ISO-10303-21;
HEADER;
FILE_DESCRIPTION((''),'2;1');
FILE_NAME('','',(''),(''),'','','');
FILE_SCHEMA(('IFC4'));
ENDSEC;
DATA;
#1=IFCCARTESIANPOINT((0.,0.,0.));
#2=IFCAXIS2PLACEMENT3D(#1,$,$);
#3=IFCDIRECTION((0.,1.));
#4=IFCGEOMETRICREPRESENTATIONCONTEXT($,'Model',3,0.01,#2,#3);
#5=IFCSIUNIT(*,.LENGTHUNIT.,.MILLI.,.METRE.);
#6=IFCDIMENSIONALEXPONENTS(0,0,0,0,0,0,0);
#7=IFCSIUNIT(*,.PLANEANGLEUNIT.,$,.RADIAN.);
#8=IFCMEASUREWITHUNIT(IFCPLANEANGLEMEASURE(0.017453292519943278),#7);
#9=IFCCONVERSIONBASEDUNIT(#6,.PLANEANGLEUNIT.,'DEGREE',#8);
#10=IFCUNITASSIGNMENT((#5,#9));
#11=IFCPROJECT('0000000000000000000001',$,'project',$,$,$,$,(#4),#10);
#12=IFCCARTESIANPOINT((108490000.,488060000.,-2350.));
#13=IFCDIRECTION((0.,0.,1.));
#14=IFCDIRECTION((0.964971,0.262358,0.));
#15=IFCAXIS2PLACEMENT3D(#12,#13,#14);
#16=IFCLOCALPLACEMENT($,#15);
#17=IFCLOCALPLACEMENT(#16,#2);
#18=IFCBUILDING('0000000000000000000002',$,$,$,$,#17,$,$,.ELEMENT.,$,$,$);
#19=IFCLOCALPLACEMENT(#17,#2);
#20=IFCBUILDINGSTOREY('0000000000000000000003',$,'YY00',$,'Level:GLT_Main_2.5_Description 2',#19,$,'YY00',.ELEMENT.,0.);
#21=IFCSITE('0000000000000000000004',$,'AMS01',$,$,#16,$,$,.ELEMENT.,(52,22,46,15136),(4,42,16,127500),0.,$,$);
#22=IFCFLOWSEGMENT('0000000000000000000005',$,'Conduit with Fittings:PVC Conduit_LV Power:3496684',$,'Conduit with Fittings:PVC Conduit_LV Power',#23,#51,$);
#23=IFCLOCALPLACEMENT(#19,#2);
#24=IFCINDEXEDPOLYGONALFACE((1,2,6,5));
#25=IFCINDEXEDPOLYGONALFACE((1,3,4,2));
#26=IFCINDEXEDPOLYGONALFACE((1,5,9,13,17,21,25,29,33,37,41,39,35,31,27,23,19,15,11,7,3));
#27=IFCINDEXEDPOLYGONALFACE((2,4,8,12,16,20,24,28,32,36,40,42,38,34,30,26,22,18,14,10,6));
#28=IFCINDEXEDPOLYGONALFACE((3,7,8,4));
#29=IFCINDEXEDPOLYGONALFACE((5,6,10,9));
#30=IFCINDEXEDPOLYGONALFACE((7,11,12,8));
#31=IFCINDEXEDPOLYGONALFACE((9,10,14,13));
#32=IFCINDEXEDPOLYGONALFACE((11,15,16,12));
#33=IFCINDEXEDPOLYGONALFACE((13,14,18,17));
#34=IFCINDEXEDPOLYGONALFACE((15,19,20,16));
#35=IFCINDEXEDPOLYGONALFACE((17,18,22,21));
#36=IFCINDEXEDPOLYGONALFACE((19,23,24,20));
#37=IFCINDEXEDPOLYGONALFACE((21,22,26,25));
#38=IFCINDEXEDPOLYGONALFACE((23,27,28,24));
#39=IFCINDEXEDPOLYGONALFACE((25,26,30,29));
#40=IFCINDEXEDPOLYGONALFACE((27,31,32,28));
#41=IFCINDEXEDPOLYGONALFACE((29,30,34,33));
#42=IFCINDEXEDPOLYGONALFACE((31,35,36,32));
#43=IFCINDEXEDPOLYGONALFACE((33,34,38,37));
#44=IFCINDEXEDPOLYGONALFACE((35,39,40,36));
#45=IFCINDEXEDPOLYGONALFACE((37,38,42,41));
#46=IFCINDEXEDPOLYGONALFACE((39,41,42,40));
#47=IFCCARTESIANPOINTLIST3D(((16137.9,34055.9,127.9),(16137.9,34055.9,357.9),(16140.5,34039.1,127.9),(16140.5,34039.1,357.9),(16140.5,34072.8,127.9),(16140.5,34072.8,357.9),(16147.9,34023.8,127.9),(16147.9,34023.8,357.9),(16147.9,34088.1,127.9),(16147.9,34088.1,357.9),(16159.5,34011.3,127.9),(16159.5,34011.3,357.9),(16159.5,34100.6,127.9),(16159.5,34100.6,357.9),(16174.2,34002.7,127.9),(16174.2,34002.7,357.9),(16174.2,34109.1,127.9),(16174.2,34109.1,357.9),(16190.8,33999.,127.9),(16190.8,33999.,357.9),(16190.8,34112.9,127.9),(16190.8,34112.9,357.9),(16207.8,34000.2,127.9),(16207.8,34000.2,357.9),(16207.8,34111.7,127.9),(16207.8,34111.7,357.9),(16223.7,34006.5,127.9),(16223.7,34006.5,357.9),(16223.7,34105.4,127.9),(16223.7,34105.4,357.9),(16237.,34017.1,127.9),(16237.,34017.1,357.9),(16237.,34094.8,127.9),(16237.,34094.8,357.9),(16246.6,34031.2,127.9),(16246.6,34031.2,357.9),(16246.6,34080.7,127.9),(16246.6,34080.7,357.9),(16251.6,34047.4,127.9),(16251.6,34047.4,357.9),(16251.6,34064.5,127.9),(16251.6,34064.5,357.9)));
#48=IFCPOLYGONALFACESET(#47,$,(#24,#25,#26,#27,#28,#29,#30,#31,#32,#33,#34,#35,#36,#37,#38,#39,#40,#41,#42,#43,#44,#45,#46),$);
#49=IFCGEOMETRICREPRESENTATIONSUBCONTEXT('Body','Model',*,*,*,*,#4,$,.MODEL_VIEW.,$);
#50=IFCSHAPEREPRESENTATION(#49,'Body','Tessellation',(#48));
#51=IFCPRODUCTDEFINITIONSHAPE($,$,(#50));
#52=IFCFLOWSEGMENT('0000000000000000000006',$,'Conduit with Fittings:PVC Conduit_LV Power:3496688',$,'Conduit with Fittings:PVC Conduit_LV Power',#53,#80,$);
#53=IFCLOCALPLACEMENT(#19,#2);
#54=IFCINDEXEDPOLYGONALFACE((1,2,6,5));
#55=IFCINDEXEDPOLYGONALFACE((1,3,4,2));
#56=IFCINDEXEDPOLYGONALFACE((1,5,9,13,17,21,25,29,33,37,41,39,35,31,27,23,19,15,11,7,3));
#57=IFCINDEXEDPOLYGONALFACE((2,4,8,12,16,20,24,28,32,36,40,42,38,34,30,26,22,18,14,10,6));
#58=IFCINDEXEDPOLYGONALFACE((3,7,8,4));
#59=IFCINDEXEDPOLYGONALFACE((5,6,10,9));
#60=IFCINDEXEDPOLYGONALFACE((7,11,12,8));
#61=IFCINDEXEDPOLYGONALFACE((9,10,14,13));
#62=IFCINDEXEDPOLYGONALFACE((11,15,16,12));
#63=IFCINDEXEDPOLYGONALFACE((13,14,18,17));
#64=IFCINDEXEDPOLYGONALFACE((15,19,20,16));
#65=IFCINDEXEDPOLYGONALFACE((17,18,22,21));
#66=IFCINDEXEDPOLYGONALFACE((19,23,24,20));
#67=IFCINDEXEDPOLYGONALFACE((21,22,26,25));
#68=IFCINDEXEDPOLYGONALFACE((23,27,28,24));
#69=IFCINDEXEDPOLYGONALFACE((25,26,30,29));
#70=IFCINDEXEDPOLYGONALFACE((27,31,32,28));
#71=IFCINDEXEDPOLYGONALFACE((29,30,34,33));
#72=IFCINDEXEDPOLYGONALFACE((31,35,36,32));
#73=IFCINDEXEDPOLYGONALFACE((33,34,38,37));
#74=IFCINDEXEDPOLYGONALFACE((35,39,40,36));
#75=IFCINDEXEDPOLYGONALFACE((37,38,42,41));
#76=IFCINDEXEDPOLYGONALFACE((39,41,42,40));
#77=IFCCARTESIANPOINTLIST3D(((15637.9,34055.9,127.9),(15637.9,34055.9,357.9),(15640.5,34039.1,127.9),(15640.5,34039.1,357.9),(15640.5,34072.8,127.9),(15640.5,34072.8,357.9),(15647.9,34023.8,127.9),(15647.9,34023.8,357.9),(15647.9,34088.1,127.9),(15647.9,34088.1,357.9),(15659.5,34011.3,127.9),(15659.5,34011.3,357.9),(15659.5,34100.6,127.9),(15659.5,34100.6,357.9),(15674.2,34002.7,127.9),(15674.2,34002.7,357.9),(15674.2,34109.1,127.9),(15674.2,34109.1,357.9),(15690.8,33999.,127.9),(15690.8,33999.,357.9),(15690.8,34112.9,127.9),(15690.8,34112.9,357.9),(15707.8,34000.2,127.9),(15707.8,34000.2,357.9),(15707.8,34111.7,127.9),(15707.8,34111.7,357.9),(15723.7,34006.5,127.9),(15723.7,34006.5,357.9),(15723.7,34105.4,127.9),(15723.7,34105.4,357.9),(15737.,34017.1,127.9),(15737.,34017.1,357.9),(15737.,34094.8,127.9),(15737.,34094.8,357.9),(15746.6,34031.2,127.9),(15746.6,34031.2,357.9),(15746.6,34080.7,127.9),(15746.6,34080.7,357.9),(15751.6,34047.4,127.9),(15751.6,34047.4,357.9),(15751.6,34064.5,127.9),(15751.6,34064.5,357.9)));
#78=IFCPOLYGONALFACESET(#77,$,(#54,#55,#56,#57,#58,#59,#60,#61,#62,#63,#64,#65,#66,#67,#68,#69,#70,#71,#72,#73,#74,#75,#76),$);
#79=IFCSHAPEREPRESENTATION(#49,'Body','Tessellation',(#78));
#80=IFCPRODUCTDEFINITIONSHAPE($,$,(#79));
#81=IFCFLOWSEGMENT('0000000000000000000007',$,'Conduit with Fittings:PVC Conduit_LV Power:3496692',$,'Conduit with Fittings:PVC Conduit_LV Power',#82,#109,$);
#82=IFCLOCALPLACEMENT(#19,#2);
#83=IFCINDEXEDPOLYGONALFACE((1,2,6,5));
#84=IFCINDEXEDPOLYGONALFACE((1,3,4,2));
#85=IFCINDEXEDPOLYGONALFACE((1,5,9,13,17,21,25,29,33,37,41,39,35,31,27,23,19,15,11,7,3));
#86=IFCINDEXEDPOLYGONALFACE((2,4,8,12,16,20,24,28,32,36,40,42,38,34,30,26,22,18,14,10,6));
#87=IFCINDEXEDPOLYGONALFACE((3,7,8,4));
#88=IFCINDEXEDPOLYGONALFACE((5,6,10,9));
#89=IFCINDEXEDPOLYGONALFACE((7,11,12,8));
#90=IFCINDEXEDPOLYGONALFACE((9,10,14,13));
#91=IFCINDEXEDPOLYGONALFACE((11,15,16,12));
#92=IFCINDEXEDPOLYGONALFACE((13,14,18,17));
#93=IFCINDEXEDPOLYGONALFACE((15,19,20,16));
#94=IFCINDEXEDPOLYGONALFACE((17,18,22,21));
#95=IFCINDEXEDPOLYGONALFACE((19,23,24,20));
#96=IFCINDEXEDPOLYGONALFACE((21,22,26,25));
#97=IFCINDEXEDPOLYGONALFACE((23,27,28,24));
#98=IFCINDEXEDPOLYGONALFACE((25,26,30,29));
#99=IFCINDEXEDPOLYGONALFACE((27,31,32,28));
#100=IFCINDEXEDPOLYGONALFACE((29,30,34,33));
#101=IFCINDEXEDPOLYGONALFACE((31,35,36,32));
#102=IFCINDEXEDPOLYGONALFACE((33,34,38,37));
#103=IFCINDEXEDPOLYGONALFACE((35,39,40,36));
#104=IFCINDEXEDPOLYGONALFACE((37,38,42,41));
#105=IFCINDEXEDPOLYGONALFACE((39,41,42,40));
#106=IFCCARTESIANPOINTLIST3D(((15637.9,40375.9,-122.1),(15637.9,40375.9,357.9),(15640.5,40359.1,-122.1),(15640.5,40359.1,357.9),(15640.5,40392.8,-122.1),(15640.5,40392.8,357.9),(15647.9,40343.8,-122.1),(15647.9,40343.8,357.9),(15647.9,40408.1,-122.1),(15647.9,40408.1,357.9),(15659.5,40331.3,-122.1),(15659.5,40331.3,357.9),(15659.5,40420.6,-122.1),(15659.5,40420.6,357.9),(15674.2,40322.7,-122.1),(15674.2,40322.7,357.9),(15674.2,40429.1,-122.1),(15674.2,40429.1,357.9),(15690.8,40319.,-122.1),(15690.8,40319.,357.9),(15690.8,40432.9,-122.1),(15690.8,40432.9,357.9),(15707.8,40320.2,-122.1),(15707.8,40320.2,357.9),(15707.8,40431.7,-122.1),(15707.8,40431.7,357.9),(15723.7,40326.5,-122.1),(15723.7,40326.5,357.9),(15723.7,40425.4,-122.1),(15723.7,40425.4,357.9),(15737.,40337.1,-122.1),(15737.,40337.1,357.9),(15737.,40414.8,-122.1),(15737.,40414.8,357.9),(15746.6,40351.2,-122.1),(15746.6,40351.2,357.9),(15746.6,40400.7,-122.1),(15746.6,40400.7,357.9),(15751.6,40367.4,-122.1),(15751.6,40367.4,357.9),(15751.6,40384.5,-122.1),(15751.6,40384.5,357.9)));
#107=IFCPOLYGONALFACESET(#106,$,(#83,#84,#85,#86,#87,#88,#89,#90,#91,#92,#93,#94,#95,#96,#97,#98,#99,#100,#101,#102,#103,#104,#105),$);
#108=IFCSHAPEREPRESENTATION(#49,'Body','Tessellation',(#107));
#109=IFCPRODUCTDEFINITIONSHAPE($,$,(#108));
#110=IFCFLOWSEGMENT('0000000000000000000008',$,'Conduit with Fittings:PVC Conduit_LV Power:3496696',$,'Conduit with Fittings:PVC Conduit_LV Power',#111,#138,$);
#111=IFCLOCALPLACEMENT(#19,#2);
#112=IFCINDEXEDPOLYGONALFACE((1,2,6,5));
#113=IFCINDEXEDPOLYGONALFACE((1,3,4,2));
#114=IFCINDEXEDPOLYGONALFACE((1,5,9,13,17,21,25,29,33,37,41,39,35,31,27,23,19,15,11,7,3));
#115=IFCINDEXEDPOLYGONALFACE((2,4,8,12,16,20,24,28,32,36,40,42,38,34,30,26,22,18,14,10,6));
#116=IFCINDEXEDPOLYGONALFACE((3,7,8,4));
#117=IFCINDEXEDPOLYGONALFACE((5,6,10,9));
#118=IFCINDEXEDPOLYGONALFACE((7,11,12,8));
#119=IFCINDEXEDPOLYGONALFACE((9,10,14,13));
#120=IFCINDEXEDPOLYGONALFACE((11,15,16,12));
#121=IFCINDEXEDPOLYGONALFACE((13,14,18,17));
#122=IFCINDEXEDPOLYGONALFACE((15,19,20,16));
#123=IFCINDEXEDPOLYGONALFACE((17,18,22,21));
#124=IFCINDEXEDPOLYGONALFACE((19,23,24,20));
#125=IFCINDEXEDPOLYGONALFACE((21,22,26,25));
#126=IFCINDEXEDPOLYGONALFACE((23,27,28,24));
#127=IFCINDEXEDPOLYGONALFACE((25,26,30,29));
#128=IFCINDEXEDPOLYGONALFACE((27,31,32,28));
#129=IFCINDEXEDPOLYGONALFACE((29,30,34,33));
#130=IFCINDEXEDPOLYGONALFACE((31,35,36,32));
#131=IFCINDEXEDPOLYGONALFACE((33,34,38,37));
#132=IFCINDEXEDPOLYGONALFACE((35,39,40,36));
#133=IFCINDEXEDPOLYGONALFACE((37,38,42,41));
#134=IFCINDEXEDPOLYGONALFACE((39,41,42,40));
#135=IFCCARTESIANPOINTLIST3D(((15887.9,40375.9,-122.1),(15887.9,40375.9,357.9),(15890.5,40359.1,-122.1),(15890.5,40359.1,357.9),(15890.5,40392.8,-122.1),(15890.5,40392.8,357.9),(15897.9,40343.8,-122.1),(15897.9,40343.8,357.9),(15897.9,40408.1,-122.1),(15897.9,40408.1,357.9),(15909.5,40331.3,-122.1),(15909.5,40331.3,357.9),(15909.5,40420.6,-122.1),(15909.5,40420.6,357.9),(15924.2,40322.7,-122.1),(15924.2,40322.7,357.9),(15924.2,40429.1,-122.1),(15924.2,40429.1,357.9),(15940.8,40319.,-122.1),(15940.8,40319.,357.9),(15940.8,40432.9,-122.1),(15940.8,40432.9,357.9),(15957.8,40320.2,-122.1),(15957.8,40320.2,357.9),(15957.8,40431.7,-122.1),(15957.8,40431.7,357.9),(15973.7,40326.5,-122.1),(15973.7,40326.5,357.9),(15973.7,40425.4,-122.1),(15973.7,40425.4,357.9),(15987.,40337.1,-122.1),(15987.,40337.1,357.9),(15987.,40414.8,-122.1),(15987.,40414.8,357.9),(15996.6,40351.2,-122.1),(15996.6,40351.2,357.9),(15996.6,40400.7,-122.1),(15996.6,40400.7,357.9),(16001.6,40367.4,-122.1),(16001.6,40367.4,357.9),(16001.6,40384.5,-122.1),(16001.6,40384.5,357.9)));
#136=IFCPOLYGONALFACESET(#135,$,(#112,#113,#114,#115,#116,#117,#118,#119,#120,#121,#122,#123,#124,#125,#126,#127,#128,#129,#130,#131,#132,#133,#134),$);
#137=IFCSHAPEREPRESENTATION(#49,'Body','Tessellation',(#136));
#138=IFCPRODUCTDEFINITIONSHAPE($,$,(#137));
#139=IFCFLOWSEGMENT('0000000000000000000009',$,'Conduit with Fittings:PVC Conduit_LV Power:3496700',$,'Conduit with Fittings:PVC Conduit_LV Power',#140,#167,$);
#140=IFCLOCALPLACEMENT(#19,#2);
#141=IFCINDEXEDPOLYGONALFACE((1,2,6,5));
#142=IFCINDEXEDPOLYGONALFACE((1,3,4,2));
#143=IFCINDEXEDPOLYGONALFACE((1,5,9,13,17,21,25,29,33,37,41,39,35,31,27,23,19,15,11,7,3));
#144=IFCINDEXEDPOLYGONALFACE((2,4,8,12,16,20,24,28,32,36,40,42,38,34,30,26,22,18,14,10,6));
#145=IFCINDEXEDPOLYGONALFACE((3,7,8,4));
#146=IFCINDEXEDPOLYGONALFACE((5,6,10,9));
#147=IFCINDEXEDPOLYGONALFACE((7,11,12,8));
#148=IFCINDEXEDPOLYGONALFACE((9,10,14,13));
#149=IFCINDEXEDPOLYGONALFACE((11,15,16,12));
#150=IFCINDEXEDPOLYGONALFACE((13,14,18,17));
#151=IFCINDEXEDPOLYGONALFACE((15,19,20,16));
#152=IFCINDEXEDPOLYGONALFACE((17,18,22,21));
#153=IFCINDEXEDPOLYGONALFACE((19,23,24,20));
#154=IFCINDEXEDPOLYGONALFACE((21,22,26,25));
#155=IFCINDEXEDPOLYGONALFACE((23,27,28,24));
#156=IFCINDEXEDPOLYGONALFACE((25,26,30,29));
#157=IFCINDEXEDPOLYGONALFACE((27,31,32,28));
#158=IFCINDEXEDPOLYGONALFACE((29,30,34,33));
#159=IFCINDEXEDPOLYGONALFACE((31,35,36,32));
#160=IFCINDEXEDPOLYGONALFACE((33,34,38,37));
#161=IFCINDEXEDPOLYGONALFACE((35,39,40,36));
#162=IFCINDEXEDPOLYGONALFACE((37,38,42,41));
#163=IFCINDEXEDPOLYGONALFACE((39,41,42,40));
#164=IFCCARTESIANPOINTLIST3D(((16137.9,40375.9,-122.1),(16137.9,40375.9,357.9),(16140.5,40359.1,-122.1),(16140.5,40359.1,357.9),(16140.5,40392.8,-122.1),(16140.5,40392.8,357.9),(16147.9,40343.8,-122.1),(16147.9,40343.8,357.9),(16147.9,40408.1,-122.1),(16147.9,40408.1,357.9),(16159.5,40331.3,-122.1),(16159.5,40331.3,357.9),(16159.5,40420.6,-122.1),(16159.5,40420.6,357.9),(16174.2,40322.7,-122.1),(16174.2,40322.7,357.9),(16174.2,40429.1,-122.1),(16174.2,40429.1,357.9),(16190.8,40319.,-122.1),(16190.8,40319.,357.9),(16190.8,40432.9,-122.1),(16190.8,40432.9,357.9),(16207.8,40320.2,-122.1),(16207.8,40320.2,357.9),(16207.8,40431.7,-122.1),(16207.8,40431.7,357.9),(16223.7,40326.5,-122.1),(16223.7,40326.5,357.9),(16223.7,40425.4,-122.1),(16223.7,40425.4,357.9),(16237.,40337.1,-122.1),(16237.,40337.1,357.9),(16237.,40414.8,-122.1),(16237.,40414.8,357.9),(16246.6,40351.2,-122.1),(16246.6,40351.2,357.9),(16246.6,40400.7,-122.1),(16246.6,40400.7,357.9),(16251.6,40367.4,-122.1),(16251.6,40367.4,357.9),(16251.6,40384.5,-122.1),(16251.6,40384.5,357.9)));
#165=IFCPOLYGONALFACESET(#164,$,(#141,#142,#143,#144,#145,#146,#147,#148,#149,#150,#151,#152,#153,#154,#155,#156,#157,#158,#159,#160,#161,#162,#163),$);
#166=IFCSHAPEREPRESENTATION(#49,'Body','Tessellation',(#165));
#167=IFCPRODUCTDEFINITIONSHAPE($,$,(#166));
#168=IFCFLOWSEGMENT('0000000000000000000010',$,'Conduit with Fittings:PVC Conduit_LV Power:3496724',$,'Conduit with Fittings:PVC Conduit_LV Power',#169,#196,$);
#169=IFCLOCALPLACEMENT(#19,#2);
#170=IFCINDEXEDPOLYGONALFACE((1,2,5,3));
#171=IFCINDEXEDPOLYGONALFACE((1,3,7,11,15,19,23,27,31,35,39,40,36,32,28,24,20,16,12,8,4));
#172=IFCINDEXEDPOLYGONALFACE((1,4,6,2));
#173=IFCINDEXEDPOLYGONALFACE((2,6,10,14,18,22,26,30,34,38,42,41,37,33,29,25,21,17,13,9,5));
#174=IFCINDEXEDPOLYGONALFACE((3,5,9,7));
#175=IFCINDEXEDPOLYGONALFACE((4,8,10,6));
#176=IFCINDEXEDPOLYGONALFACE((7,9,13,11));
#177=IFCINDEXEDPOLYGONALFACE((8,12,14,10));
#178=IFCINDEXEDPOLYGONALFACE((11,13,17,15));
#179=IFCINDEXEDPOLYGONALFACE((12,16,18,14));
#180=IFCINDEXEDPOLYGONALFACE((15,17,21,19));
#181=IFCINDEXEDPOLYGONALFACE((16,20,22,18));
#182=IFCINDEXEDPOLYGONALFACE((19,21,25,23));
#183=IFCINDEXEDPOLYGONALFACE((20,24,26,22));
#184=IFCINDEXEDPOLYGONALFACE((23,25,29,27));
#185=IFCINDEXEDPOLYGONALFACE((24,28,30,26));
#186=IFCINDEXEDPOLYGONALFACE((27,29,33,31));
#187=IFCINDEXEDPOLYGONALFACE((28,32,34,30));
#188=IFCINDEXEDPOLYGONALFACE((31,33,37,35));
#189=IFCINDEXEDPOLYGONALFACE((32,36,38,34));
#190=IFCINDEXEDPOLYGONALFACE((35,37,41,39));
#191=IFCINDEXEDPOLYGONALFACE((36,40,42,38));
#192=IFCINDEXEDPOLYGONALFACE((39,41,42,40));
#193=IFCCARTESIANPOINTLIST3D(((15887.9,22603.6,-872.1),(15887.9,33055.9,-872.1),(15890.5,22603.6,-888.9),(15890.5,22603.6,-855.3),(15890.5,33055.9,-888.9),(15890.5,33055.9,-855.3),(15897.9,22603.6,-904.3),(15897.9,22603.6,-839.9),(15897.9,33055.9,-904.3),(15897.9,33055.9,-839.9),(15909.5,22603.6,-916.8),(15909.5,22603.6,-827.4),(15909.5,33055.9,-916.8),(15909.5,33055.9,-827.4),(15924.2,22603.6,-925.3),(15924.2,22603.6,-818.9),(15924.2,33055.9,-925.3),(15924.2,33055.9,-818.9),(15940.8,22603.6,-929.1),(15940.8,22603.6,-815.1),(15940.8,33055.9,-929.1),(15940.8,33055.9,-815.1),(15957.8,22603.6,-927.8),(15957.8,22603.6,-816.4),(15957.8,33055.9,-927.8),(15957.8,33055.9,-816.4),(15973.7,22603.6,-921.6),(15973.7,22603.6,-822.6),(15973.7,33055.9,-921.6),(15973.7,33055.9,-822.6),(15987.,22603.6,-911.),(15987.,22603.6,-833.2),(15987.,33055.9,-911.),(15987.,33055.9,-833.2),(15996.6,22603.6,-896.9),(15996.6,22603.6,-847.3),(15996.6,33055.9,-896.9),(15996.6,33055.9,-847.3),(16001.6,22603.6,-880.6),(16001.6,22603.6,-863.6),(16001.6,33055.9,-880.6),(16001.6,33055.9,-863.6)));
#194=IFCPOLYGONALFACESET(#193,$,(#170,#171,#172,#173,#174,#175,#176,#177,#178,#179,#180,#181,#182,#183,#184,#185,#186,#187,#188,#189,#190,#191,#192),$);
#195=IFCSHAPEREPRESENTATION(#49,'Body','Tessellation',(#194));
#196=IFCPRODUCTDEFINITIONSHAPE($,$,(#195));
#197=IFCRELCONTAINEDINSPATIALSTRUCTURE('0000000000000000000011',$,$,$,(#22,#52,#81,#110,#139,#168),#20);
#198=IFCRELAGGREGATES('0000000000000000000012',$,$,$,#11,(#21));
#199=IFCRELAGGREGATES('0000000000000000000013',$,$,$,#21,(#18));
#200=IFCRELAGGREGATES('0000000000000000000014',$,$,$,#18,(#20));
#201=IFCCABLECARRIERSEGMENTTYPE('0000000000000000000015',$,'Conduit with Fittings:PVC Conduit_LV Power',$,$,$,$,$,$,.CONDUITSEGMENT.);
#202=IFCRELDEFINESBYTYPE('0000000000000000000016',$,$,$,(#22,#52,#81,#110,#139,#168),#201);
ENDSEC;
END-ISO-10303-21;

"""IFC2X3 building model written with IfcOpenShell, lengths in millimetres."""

from ifc_helpers import new_model, entity, si_unit, converted_unit, direction, frame, frame_2d, origin, origin_2d_with_axis, place, context, subcontext, project, spatial, circle, extrude, type_object, element, save


model = new_model("IFC2X3")

# Units and contexts
model_context = context("Model", 3, precision=0.01, world=origin(), true_north=direction((0.0, 1.0)))
body_context = subcontext(model_context, "Body", "Model", "MODEL_VIEW")
ifc_project = project(units=[si_unit("LENGTHUNIT", "METRE", prefix="MILLI"), converted_unit("PLANEANGLEUNIT", "DEGREE", entity("IfcPlaneAngleMeasure", 0.017453292519943278), si_unit("PLANEANGLEUNIT", "RADIAN"), dimensions=[0, 0, 0, 0, 0, 0, 0])], contexts=[model_context])

# Site, building, storey
site_placement = place(None, frame((108490000.0, 488060000.0, -2350.0), z_axis=(0.0, 0.0, 1.0), x_axis=(0.964971, 0.262358, 0.0)))
site = spatial("IfcSite", under=ifc_project, at=site_placement, Name="AMS01", CompositionType="ELEMENT", RefLatitude=(52, 22, 46, 15136), RefLongitude=(4, 42, 16, 127500), RefElevation=0.0)
building_placement = place(site_placement, origin())
building = spatial("IfcBuilding", under=site, at=building_placement, CompositionType="ELEMENT")
storey_placement = place(building_placement, origin())
storey = spatial("IfcBuildingStorey", under=building, at=storey_placement, Name="YY00", ObjectType="Level:GLT_Main_2.5_Description 2", LongName="YY00", CompositionType="ELEMENT", Elevation=0.0)

# Flow segments
cable_carrier_segment_type = type_object("IfcCableCarrierSegmentType", Name="Conduit with Fittings:PVC Conduit_LV Power", PredefinedType="CONDUITSEGMENT")
flow_segment_1_placement = place(storey_placement, origin())
element("IfcFlowSegment", 1, at=flow_segment_1_placement, inside=storey, type_object=cable_carrier_segment_type, Name="Conduit with Fittings:PVC Conduit_LV Power:3496684", ObjectType="Conduit with Fittings:PVC Conduit_LV Power", context=body_context, shape_type="SweptSolid", body=[
    extrude(circle(Radius=57.2, at=origin_2d_with_axis()), frame((16195.1, 34055.9, 127.9), z_axis=(0.0, 0.0, 1.0), x_axis=(-1.0, 0.0, 0.0)), (0.0, 0.0, 1.0), 230.0),
])
flow_segment_2_placement = place(storey_placement, origin())
element("IfcFlowSegment", 2, at=flow_segment_2_placement, inside=storey, type_object=cable_carrier_segment_type, Name="Conduit with Fittings:PVC Conduit_LV Power:3496688", ObjectType="Conduit with Fittings:PVC Conduit_LV Power", context=body_context, shape_type="SweptSolid", body=[
    extrude(circle(Radius=57.2, at=origin_2d_with_axis()), frame((15695.1, 34055.9, 127.9), z_axis=(0.0, 0.0, 1.0), x_axis=(-1.0, 0.0, 0.0)), (0.0, 0.0, 1.0), 230.0),
])
flow_segment_3_placement = place(storey_placement, origin())
element("IfcFlowSegment", 3, at=flow_segment_3_placement, inside=storey, type_object=cable_carrier_segment_type, Name="Conduit with Fittings:PVC Conduit_LV Power:3496692", ObjectType="Conduit with Fittings:PVC Conduit_LV Power", context=body_context, shape_type="SweptSolid", body=[
    extrude(circle(Radius=57.2, at=origin_2d_with_axis()), frame((15695.1, 40375.9, -122.1), z_axis=(0.0, 0.0, 1.0), x_axis=(-1.0, 0.0, 0.0)), (0.0, 0.0, 1.0), 480.0),
])
flow_segment_4_placement = place(storey_placement, origin())
element("IfcFlowSegment", 4, at=flow_segment_4_placement, inside=storey, type_object=cable_carrier_segment_type, Name="Conduit with Fittings:PVC Conduit_LV Power:3496696", ObjectType="Conduit with Fittings:PVC Conduit_LV Power", context=body_context, shape_type="SweptSolid", body=[
    extrude(circle(Radius=57.2, at=origin_2d_with_axis()), frame((15945.1, 40375.9, -122.1), z_axis=(0.0, 0.0, 1.0), x_axis=(-1.0, 0.0, 0.0)), (0.0, 0.0, 1.0), 480.0),
])
flow_segment_5_placement = place(storey_placement, origin())
element("IfcFlowSegment", 5, at=flow_segment_5_placement, inside=storey, type_object=cable_carrier_segment_type, Name="Conduit with Fittings:PVC Conduit_LV Power:3496700", ObjectType="Conduit with Fittings:PVC Conduit_LV Power", context=body_context, shape_type="SweptSolid", body=[
    extrude(circle(Radius=57.2, at=origin_2d_with_axis()), frame((16195.1, 40375.9, -122.1), z_axis=(0.0, 0.0, 1.0), x_axis=(-1.0, 0.0, 0.0)), (0.0, 0.0, 1.0), 480.0),
])
flow_segment_6_placement = place(storey_placement, origin())
element("IfcFlowSegment", 6, at=flow_segment_6_placement, inside=storey, type_object=cable_carrier_segment_type, Name="Conduit with Fittings:PVC Conduit_LV Power:3496724", ObjectType="Conduit with Fittings:PVC Conduit_LV Power", context=body_context, shape_type="SweptSolid", body=[
    extrude(circle(Radius=57.2, at=frame_2d((0.0, 0.0), x_axis=(1.0, 0.0))), frame((15945.1, 22603.6, -872.1), z_axis=(0.0, 1.0, 0.0), x_axis=(-1.0, 0.0, 0.0)), (0.0, 0.0, 1.0), 10452.4),
])

save(model, "model.ifc")
